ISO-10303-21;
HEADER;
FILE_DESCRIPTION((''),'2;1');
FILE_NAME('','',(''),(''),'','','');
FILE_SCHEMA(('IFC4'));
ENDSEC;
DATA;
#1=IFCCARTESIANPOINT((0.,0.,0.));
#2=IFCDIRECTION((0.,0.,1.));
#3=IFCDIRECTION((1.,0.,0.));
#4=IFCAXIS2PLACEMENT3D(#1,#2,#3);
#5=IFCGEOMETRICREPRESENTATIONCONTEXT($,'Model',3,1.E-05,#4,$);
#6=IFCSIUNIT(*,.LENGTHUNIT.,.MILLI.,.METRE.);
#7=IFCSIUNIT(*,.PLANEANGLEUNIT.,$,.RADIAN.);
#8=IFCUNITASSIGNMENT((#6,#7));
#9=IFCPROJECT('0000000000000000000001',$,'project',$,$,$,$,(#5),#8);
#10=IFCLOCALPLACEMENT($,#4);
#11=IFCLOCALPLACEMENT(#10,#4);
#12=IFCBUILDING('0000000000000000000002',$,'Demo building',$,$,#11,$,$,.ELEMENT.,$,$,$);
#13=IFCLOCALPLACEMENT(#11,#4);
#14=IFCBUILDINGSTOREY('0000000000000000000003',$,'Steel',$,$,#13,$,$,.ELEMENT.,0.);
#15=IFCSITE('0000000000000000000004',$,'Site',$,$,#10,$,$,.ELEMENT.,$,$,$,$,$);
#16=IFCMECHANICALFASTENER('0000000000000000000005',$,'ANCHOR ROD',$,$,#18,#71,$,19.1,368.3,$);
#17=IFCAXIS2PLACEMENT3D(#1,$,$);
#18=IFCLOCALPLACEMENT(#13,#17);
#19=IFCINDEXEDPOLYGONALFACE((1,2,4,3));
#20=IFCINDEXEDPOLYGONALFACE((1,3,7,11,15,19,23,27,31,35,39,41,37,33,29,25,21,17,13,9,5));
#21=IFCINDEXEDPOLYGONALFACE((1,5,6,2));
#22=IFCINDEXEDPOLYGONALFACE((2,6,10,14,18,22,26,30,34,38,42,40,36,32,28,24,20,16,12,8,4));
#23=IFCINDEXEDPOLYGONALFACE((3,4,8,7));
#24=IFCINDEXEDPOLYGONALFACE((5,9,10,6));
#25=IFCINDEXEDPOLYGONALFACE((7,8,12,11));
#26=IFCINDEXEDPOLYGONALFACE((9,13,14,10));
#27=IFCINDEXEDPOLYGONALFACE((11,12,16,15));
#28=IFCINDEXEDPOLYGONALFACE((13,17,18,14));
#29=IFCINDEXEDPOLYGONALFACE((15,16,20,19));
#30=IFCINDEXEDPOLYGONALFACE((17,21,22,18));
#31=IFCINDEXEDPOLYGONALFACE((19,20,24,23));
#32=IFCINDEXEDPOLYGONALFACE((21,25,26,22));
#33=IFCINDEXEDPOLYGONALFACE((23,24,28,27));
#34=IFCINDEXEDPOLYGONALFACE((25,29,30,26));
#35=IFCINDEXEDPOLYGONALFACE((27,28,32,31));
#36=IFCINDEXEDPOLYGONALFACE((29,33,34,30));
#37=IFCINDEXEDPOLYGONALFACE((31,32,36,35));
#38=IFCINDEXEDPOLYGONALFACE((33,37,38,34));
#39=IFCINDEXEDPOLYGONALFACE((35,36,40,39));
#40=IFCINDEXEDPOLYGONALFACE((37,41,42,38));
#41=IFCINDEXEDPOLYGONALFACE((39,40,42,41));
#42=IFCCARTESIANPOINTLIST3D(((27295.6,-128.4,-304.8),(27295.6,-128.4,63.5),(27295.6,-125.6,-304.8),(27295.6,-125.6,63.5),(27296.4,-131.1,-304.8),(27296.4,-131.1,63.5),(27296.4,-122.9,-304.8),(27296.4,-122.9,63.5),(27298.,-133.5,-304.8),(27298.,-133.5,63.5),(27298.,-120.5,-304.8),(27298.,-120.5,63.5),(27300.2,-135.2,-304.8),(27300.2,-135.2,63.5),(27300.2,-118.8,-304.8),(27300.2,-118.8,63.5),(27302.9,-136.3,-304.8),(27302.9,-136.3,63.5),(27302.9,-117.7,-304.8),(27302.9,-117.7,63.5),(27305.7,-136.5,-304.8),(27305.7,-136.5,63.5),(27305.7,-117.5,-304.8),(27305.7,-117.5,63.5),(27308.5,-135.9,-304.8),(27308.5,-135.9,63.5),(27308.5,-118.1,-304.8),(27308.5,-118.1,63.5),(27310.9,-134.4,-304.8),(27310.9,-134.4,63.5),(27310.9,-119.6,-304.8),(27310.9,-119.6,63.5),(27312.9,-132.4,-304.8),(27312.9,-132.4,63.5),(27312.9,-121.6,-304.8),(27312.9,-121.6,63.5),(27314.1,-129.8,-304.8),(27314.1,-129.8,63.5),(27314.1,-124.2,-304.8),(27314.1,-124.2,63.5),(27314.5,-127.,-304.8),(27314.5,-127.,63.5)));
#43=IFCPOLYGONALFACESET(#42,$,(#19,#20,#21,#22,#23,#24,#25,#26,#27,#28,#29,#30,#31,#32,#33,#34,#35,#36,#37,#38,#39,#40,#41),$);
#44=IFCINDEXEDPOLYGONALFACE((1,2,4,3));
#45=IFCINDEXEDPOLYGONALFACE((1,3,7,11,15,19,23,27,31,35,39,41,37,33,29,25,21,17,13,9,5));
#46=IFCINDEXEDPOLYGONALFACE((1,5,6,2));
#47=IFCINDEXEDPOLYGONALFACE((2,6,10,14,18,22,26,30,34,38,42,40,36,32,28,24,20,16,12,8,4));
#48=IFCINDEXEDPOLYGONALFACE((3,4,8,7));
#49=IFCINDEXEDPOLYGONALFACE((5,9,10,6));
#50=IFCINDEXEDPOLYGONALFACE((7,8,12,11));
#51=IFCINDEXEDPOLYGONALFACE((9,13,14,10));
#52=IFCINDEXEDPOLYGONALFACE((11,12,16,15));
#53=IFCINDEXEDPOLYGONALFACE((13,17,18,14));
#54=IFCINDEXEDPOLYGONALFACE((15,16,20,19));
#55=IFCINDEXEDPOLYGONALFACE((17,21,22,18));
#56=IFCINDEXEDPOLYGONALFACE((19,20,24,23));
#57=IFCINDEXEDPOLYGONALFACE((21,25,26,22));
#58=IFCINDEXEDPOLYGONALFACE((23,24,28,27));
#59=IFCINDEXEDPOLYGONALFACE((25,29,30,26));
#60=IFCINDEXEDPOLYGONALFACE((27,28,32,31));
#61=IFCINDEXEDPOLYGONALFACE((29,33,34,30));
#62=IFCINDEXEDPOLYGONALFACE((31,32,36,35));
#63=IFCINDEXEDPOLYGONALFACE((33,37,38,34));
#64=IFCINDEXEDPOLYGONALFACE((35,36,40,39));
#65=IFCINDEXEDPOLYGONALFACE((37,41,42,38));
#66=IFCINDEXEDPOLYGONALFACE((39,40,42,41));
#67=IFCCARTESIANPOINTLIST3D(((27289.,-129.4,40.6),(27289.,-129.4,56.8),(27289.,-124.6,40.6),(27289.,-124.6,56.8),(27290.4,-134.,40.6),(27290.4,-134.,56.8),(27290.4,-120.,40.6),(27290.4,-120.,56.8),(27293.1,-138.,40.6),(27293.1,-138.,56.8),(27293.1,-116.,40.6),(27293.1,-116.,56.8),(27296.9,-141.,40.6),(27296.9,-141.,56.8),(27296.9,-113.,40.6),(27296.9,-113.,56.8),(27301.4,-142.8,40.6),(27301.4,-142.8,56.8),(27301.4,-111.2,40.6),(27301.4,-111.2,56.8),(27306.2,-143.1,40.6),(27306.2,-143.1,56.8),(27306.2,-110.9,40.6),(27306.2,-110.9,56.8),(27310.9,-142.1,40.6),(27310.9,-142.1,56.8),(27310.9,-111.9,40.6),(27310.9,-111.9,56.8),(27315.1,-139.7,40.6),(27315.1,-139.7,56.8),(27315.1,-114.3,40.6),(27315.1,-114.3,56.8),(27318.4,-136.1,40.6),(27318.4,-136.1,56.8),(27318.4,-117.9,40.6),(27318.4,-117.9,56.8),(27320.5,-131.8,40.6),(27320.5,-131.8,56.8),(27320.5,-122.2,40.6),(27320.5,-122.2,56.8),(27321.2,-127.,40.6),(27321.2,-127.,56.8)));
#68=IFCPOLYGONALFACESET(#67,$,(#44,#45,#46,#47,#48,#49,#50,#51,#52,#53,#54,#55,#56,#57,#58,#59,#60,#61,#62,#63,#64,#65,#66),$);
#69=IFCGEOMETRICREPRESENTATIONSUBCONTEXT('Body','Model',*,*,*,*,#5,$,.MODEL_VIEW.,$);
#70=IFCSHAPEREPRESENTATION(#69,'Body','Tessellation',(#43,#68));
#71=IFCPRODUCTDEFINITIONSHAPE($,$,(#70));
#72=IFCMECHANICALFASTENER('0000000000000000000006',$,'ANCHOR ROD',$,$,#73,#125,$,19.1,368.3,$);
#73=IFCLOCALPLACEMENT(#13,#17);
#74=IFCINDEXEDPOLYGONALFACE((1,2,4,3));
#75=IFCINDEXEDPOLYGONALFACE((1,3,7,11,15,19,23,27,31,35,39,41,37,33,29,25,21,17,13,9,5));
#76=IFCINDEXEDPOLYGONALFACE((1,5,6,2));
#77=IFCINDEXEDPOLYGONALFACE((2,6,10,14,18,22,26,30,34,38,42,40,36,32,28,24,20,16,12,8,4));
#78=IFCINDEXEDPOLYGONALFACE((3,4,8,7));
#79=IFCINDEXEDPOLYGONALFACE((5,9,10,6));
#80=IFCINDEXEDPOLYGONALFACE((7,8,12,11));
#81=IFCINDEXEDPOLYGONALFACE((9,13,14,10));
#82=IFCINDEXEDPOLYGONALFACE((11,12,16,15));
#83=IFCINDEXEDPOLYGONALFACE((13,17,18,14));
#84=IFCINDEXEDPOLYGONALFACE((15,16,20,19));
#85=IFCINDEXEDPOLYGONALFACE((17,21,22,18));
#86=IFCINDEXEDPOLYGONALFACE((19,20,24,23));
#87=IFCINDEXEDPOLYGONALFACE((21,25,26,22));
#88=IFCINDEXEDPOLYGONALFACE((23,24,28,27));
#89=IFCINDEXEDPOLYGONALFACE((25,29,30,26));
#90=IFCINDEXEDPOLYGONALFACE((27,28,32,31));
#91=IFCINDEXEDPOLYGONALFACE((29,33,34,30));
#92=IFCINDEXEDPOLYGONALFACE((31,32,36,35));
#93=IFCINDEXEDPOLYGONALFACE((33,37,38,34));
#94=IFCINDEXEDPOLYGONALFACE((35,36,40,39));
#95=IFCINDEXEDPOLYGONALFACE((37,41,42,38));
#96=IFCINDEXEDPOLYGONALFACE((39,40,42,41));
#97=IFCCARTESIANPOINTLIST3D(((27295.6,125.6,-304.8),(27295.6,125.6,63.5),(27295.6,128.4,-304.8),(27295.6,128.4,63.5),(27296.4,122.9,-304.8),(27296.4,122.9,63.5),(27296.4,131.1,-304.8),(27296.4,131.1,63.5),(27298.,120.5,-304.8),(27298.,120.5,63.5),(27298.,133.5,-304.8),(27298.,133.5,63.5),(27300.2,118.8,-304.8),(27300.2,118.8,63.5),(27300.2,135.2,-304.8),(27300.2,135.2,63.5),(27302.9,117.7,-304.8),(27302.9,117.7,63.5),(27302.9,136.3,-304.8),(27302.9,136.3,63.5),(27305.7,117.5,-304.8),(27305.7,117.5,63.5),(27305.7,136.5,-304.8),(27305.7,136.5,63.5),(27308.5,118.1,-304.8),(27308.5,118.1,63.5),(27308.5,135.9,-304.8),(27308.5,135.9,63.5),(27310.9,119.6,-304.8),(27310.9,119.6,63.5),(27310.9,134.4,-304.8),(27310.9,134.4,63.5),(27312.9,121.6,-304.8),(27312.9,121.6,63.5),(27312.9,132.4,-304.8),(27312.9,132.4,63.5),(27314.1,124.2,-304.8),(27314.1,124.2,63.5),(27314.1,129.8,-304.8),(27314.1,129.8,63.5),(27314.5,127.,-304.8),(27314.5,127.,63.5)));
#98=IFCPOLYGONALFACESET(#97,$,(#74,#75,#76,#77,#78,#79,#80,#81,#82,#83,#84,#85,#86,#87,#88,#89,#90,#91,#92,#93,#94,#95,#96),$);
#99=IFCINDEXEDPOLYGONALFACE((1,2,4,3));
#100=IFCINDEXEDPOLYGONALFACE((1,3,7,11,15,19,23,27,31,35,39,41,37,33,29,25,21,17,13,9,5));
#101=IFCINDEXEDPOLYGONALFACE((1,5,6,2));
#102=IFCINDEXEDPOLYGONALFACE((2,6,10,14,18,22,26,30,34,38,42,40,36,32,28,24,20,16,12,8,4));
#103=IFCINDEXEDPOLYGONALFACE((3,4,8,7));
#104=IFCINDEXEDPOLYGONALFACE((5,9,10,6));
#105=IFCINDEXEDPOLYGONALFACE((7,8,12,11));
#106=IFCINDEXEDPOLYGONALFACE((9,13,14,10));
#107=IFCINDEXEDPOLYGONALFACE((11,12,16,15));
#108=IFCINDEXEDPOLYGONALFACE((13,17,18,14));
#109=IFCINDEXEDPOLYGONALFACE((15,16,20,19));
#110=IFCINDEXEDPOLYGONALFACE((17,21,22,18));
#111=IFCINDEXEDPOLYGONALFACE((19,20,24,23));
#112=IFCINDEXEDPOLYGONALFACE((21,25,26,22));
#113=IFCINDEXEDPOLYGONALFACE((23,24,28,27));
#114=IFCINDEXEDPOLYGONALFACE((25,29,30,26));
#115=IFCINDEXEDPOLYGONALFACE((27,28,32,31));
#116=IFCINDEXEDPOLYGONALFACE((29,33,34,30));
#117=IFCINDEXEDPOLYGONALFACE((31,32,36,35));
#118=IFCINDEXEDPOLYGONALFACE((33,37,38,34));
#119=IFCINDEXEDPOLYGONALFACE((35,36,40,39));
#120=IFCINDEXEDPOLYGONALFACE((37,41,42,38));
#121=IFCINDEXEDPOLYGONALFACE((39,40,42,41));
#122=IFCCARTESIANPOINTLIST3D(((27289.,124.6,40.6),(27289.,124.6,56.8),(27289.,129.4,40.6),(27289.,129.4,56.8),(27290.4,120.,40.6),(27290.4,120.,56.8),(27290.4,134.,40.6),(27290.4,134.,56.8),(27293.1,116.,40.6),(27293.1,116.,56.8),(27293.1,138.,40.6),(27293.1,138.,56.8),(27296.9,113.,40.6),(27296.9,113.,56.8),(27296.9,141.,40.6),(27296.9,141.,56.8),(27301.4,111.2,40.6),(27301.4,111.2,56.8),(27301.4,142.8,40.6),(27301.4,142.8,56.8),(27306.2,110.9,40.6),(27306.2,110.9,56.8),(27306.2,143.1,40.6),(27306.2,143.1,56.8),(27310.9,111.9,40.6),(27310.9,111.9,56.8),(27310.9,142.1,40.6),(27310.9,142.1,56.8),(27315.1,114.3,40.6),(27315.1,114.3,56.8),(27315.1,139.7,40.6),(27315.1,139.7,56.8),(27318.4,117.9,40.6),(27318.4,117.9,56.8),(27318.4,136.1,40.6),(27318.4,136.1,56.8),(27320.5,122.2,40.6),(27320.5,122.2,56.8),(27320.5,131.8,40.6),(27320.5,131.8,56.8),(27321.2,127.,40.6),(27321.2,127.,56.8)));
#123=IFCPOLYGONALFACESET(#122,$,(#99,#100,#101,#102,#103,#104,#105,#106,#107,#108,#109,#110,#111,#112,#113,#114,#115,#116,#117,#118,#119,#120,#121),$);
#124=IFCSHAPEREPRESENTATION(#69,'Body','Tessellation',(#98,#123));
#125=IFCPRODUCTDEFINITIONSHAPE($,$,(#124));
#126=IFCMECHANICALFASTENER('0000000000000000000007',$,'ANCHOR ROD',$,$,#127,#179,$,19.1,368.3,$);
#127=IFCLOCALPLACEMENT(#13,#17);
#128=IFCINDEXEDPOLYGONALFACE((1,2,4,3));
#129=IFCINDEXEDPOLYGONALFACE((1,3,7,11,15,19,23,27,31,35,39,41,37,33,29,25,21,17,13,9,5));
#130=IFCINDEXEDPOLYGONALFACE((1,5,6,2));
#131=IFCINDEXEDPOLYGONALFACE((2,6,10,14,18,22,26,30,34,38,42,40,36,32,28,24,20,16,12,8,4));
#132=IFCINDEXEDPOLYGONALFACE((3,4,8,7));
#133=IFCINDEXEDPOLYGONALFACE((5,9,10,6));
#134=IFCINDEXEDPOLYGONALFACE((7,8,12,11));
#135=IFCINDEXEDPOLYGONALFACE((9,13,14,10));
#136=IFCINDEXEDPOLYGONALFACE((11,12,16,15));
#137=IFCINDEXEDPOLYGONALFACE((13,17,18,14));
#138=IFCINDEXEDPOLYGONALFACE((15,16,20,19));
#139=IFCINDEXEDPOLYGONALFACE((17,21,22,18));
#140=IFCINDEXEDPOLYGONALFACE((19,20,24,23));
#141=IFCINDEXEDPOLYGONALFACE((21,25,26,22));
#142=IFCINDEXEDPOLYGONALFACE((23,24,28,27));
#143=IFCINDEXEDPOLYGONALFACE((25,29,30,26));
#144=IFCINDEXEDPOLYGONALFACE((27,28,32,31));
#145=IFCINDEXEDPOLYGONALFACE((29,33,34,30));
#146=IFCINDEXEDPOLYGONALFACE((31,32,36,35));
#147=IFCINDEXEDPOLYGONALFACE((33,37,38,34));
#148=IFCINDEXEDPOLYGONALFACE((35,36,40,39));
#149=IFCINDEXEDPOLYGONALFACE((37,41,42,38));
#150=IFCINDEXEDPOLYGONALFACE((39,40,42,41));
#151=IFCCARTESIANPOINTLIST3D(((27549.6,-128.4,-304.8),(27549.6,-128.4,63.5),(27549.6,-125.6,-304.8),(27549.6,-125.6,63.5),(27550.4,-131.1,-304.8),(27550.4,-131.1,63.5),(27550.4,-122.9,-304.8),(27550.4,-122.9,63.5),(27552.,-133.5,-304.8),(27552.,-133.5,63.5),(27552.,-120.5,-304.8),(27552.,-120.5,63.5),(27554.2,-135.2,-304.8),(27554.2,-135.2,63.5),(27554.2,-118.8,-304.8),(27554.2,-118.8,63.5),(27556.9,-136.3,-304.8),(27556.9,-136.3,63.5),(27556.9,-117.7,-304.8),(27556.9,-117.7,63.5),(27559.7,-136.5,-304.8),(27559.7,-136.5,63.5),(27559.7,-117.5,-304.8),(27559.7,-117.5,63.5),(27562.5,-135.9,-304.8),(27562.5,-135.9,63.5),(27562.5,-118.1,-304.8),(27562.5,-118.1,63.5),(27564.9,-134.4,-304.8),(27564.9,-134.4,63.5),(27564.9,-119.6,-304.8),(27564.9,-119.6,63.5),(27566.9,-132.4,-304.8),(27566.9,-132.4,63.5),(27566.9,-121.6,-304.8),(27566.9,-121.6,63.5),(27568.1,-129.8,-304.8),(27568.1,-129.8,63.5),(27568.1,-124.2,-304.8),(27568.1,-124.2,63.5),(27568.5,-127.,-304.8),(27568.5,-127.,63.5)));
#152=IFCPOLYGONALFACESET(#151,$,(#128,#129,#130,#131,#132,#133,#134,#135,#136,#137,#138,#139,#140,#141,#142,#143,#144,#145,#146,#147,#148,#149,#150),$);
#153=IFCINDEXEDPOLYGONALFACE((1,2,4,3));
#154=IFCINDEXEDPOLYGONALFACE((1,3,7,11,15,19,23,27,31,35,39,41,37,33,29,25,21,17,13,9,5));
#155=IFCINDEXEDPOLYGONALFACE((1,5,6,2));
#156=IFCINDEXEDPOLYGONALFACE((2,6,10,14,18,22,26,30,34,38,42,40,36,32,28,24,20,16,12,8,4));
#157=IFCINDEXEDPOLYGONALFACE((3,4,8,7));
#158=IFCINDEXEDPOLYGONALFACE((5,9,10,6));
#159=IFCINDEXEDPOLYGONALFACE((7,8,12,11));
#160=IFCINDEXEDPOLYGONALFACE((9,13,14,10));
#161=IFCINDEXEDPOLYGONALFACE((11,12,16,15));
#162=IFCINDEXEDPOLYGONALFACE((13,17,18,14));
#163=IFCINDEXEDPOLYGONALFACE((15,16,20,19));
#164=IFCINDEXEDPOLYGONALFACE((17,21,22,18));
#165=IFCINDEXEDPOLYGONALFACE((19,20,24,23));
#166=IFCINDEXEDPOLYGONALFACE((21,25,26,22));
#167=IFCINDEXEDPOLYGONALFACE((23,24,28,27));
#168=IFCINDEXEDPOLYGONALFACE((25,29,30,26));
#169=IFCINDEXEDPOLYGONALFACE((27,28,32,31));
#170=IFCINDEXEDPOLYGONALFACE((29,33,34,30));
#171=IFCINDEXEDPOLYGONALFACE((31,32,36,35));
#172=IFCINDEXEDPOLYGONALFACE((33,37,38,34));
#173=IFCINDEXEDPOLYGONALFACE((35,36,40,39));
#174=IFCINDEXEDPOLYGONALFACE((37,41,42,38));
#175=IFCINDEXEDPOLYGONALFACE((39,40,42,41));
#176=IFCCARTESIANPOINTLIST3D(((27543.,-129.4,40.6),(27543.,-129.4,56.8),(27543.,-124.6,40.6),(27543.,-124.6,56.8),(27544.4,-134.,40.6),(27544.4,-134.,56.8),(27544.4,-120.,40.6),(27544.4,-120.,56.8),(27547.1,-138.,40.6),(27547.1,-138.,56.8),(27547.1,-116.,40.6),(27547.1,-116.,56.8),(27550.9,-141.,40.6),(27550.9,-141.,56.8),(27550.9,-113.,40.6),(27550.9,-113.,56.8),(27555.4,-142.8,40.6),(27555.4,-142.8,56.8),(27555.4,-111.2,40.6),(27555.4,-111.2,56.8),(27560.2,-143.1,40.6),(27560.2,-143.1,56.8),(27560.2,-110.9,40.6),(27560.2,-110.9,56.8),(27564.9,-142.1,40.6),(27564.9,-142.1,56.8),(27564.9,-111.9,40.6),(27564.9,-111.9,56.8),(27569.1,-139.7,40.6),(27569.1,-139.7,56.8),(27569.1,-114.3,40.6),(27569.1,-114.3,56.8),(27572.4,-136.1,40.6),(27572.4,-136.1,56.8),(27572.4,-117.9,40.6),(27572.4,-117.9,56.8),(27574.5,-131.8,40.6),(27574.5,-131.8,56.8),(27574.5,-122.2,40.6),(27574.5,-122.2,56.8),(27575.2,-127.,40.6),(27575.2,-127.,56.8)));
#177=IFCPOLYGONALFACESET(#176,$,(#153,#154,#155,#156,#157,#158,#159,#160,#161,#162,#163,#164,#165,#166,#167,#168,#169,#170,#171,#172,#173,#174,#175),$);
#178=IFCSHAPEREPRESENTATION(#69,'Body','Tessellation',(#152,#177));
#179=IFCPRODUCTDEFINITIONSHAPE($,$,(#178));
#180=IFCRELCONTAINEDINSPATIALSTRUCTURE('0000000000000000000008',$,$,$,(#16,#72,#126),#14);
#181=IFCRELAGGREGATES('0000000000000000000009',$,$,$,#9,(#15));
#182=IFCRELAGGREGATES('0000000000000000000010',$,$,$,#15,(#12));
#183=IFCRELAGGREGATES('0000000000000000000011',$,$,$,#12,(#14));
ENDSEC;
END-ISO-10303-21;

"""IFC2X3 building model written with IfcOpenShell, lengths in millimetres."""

from ifc_helpers import new_model, si_unit, frame, origin, origin_with_axes, origin_2d, place, context, subcontext, project, spatial, circle, extrude, element, save


model = new_model("IFC2X3")

# Units and contexts
model_context = context("Model", 3, precision=1e-05, world=origin_with_axes())
body_context = subcontext(model_context, "Body", "Model", "MODEL_VIEW")
ifc_project = project(units=[si_unit("LENGTHUNIT", "METRE", prefix="MILLI"), si_unit("PLANEANGLEUNIT", "RADIAN")], contexts=[model_context])

# Site, building, storey
site_placement = place(None, origin_with_axes())
site = spatial("IfcSite", under=ifc_project, at=site_placement, Name="Site", CompositionType="ELEMENT")
building_placement = place(site_placement, origin_with_axes())
building = spatial("IfcBuilding", under=site, at=building_placement, Name="Demo building", CompositionType="ELEMENT")
placement = place(building_placement, origin_with_axes())
storey = spatial("IfcBuildingStorey", under=building, at=placement, Name="Steel", CompositionType="ELEMENT", Elevation=0.0)

# Mechanical fasteners
for number, where, z_axis, x_axis, name in (
    (1, (27305.0, -127.0, -304.8), (0.0, 0.0, 1.0), (1.0, 0.0, 0.0), "ANCHOR ROD"),
    (2, (27305.0, 127.0, -304.8), (0.0, 0.0, 1.0), (1.0, 0.0, 0.0), "ANCHOR ROD"),
    (3, (27559.0, -127.0, -304.8), (0.0, 0.0, 1.0), (1.0, 0.0, 0.0), "ANCHOR ROD"),
):
    element("IfcMechanicalFastener", number, at=place(placement, frame(where, z_axis=z_axis, x_axis=x_axis)), inside=storey, Name=name, NominalDiameter=19.1, NominalLength=368.3, context=body_context, shape_type="SweptSolid", body=[
        extrude(circle(Radius=9.5, at=origin_2d()), origin(), (0.0, 0.0, 1.0), 368.3),
        extrude(circle(Radius=16.2, at=origin_2d()), frame((0.0, 0.0, 345.4)), (0.0, 0.0, 1.0), 16.2),
    ])

save(model, "model.ifc")
